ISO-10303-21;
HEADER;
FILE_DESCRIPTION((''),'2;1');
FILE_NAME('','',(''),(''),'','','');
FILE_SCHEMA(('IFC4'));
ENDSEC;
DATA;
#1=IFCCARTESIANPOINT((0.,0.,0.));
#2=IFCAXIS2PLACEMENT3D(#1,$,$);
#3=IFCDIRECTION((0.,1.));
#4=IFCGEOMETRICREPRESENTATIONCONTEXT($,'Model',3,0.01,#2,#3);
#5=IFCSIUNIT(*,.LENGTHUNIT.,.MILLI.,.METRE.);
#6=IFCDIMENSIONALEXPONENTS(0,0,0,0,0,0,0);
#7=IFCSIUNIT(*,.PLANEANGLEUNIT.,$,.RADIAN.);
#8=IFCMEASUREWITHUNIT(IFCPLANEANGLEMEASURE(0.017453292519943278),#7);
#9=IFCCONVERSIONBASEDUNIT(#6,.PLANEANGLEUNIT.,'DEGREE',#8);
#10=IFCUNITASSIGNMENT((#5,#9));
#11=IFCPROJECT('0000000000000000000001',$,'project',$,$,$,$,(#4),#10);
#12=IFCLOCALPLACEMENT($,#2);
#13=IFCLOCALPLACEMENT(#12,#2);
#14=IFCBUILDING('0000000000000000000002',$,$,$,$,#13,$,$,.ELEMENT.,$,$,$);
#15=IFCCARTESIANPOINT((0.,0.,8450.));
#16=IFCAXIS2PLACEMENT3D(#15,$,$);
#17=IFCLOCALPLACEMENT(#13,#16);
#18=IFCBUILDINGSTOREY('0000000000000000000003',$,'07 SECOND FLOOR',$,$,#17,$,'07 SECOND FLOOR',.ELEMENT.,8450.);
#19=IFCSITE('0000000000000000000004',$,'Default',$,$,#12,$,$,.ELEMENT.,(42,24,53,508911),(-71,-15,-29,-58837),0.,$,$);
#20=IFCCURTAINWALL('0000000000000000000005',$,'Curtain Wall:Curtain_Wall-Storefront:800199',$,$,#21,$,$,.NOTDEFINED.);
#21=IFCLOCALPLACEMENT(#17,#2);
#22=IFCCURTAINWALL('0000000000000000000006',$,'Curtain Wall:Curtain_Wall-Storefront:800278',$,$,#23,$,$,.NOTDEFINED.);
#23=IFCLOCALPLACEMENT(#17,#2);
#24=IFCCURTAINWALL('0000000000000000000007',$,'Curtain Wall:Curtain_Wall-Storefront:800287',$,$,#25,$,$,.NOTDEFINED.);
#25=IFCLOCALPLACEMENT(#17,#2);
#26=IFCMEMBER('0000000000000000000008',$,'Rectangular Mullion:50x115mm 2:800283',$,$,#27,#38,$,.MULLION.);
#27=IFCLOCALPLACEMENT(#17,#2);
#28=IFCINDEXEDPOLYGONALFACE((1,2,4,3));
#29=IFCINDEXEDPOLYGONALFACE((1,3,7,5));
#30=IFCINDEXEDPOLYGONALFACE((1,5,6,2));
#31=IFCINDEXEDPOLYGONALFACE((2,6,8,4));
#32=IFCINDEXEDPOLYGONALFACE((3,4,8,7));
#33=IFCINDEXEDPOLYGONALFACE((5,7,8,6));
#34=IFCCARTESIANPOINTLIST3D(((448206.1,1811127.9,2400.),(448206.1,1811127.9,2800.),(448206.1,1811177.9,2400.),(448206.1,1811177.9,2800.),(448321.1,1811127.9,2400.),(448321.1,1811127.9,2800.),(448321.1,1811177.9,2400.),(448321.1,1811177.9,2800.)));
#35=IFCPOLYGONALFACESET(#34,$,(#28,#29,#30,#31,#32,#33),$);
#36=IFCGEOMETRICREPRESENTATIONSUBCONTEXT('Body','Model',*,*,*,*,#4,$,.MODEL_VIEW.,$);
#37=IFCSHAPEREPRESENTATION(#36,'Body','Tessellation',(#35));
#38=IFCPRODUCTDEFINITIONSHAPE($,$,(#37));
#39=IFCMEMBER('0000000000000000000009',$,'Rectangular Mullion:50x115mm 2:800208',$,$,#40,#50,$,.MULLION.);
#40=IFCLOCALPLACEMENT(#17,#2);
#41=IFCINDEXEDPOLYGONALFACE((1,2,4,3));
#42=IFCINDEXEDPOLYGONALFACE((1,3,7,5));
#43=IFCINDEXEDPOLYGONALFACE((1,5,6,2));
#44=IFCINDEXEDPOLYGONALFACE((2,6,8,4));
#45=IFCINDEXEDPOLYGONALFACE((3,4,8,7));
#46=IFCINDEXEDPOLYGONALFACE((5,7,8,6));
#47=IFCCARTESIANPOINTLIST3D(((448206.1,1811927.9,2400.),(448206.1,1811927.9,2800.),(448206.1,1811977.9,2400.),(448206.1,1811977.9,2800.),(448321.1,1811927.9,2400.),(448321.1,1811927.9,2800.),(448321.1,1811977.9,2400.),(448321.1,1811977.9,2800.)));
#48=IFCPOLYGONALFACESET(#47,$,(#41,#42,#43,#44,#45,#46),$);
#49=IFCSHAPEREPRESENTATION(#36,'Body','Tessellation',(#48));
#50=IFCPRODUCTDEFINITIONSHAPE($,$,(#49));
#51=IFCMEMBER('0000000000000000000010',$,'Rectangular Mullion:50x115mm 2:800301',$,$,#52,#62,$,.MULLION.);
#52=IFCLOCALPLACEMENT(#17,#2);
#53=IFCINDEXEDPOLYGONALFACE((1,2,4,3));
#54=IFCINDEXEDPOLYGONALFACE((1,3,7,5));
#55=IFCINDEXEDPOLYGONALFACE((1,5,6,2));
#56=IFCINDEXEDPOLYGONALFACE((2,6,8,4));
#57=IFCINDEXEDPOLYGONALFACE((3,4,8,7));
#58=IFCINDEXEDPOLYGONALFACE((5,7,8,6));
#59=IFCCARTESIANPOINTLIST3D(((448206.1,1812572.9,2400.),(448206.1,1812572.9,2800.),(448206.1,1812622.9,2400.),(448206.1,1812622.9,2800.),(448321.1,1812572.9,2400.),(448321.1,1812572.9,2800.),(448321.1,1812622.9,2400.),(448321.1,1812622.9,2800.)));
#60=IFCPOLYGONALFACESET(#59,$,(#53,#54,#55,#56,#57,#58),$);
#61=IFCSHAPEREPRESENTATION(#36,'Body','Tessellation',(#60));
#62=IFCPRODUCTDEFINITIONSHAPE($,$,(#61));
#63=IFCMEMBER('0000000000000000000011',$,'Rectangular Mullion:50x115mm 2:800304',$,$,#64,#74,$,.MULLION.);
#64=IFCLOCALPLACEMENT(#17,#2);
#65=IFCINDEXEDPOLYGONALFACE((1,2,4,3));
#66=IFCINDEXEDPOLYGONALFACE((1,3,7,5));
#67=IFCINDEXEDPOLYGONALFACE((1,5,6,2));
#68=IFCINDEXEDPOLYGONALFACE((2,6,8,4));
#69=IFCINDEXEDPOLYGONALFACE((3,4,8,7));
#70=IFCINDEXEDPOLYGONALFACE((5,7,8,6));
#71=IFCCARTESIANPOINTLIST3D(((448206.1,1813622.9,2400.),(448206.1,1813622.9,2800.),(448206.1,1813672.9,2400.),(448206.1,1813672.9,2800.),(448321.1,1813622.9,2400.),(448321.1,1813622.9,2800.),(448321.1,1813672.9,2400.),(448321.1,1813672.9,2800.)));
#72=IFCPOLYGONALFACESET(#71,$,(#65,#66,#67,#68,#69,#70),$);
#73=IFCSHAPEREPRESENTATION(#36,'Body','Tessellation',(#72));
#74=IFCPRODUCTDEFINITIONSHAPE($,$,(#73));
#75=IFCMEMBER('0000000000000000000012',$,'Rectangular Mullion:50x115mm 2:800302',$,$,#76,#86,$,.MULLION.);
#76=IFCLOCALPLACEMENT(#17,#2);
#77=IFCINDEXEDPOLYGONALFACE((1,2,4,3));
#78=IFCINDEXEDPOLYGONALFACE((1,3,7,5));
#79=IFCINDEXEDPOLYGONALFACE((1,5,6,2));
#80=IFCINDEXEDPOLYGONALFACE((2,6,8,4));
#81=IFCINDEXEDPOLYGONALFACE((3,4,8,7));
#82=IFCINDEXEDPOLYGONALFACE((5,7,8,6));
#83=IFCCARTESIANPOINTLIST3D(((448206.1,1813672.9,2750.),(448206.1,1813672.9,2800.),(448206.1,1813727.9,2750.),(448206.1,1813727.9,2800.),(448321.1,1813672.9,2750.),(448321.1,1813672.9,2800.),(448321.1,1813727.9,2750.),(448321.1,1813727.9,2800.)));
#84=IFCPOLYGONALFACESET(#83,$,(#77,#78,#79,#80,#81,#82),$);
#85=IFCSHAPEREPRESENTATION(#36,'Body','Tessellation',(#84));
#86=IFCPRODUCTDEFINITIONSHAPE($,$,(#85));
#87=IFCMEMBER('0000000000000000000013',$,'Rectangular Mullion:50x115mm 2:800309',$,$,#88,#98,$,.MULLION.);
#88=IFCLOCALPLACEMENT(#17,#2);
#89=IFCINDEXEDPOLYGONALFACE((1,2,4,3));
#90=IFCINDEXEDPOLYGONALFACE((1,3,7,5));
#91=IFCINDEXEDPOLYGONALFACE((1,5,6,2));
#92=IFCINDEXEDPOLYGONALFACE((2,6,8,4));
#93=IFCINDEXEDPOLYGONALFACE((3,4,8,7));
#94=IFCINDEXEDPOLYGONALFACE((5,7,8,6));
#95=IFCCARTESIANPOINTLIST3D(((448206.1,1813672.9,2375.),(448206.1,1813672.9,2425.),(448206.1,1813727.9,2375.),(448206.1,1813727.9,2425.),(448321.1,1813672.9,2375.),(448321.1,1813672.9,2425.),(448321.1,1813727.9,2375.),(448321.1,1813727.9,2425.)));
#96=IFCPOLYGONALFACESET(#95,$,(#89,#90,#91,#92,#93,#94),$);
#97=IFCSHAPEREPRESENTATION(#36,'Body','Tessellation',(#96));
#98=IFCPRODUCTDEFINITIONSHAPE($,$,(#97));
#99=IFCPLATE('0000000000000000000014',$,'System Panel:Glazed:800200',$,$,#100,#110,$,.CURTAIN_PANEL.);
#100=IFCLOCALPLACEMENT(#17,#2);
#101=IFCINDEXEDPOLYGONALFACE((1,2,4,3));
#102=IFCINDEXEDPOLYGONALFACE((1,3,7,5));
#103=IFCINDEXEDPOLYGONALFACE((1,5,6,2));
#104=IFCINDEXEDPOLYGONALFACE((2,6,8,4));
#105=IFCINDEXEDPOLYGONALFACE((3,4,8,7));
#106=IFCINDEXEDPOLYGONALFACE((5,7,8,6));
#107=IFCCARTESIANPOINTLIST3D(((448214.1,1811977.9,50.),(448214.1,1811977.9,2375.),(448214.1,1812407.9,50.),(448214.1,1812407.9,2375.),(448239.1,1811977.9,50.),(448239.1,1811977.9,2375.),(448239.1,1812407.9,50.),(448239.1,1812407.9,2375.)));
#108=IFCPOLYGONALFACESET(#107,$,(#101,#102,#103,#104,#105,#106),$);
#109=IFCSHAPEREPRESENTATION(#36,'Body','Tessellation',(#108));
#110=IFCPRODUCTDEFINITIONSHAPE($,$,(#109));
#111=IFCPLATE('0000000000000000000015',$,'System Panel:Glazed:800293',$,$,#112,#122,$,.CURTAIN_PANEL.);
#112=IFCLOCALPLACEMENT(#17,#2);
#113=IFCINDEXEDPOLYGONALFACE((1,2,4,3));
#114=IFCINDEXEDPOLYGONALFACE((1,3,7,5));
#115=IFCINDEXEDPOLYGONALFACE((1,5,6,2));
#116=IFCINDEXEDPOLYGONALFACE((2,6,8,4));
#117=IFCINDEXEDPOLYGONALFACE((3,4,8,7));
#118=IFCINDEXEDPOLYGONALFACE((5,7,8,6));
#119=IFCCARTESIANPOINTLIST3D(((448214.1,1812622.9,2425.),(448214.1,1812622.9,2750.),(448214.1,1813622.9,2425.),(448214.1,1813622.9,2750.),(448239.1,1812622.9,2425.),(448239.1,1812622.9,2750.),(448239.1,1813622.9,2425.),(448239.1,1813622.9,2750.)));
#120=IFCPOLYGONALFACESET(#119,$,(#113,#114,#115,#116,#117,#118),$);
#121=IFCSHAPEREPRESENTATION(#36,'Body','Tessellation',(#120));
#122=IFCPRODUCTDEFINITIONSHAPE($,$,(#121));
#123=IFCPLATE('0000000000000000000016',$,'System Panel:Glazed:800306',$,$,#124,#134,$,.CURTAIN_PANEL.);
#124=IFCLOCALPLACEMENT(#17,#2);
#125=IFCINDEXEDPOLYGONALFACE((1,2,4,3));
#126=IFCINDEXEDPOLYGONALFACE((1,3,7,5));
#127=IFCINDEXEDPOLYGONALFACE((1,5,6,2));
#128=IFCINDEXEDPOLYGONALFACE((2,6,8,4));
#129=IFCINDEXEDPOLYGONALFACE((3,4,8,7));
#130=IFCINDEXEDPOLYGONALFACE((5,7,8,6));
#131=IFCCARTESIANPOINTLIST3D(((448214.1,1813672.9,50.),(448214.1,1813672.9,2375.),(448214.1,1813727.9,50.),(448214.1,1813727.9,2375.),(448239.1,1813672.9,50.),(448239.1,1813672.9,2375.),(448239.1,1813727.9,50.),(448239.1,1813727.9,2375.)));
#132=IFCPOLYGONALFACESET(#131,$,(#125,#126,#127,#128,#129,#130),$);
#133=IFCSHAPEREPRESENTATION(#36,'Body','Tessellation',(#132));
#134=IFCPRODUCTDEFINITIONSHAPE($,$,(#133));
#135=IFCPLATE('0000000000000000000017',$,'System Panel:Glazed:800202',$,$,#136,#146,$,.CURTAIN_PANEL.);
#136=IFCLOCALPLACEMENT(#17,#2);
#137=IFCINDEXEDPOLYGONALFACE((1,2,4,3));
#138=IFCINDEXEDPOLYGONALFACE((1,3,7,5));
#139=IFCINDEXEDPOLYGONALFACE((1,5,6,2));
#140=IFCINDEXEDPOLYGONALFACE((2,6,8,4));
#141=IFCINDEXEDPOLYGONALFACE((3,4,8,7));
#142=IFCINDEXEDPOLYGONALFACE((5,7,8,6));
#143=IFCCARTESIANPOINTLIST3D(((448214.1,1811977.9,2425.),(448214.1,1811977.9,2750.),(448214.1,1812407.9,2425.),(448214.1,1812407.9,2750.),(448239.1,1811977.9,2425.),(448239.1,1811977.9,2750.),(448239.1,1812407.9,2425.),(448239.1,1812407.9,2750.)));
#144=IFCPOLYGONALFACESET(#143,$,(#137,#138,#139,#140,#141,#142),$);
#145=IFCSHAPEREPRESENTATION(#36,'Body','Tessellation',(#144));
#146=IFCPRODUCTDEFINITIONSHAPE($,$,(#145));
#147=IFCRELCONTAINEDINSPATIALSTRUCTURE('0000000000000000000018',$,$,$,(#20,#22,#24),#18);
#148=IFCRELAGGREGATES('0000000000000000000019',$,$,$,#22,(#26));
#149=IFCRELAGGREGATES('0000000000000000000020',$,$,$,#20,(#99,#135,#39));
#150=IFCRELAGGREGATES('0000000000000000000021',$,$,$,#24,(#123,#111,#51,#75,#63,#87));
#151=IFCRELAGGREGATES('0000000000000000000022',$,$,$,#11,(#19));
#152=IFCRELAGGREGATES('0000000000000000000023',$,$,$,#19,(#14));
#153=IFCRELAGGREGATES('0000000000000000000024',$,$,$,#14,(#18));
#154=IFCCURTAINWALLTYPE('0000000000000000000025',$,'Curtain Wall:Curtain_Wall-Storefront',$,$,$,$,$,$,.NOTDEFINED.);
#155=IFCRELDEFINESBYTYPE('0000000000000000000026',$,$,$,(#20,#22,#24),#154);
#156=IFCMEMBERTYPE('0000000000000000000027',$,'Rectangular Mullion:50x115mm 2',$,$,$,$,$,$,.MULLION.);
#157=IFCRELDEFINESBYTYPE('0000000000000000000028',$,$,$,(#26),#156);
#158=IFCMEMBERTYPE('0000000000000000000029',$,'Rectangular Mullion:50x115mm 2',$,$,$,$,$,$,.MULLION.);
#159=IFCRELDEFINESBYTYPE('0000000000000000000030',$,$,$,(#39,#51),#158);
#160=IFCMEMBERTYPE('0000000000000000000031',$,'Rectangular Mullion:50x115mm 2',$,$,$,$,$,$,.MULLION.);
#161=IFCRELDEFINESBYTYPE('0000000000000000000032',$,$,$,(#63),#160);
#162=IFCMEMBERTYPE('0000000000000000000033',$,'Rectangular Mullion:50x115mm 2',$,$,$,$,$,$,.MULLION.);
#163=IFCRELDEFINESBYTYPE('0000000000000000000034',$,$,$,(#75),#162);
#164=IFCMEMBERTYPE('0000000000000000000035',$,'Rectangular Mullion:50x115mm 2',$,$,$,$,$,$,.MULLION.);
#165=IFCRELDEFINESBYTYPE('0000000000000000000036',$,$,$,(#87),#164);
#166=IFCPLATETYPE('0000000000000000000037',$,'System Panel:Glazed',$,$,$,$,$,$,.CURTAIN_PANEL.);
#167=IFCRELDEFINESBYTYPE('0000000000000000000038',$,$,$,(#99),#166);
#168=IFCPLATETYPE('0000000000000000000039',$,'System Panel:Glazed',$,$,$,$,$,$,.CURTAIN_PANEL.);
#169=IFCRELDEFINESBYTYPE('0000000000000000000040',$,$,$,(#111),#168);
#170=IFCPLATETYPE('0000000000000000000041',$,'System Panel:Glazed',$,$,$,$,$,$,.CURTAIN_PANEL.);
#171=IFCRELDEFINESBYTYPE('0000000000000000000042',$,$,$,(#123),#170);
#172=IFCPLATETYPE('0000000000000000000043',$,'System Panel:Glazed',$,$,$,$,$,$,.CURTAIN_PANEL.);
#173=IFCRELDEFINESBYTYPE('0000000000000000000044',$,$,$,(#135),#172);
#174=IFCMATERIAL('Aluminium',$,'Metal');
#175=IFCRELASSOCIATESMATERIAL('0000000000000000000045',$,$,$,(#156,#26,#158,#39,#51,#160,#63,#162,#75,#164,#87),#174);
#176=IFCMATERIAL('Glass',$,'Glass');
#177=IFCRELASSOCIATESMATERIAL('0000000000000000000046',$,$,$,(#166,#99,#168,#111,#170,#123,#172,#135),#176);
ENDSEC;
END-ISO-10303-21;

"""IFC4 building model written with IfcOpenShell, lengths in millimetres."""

from ifc_helpers import new_model, entity, si_unit, converted_unit, direction, frame, origin, place, context, subcontext, project, spatial, indexed_curve, outline, extrude, source, transform, mapped, material, type_object, type_shapes, element, aggregate, save


model = new_model("IFC4")

# Units and contexts
model_context = context("Model", 3, precision=0.01, world=origin(), true_north=direction((0.0, 1.0)))
body_context = subcontext(model_context, "Body", "Model", "MODEL_VIEW")
ifc_project = project(units=[si_unit("LENGTHUNIT", "METRE", prefix="MILLI"), converted_unit("PLANEANGLEUNIT", "DEGREE", entity("IfcPlaneAngleMeasure", 0.017453292519943278), si_unit("PLANEANGLEUNIT", "RADIAN"), dimensions=[0, 0, 0, 0, 0, 0, 0])], contexts=[model_context])

# Site, building, storey
site_placement = place(None, origin())
site = spatial("IfcSite", under=ifc_project, at=site_placement, Name="Default", CompositionType="ELEMENT", RefLatitude=(42, 24, 53, 508911), RefLongitude=(-71, -15, -29, -58837), RefElevation=0.0)
building_placement = place(site_placement, origin())
building = spatial("IfcBuilding", under=site, at=building_placement, CompositionType="ELEMENT")
storey_placement = place(building_placement, frame((0.0, 0.0, 8450.0)))
storey = spatial("IfcBuildingStorey", under=building, at=storey_placement, Name="07 SECOND FLOOR", LongName="07 SECOND FLOOR", CompositionType="ELEMENT", Elevation=8450.0)

# Curtain wall
curtain_wall_type = type_object("IfcCurtainWallType", Name="Curtain Wall:Curtain_Wall-Storefront", PredefinedType="NOTDEFINED")
curtain_wall_1_placement = place(storey_placement, frame((0.0, 0.0, -8450.0)))
curtain_wall_1 = element("IfcCurtainWall", 1, at=curtain_wall_1_placement, inside=storey, type_object=curtain_wall_type, Name="Curtain Wall:Curtain_Wall-Storefront:800199", PredefinedType="NOTDEFINED")
ifc_material_1 = material(Name="Aluminium", Category="Metal")

# Curtain wall
curtain_wall_2_placement = place(storey_placement, frame((0.0, 0.0, -8450.0)))
curtain_wall_2 = element("IfcCurtainWall", 2, at=curtain_wall_2_placement, inside=storey, type_object=curtain_wall_type, Name="Curtain Wall:Curtain_Wall-Storefront:800278", PredefinedType="NOTDEFINED")

# Curtain wall
curtain_wall_3_placement = place(storey_placement, frame((0.0, 0.0, -8450.0)))
curtain_wall_3 = element("IfcCurtainWall", 3, at=curtain_wall_3_placement, inside=storey, type_object=curtain_wall_type, Name="Curtain Wall:Curtain_Wall-Storefront:800287", PredefinedType="NOTDEFINED")

# Members
member_type_1 = type_object("IfcMemberType", Name="Rectangular Mullion:50x115mm 2", PredefinedType="MULLION", material=ifc_material_1)
shared_shape_1 = source(origin(), body_context, "Body", "SweptSolid", [
    extrude(outline(indexed_curve([(-25.0, -57.5), (25.0, -57.5), (25.0, 57.5), (-25.0, 57.5), (-25.0, -57.5)], self_intersect=False)), frame((-25.0, 0.0, -400.0), z_axis=(0.0, 0.0, 1.0), x_axis=(-1.0, 0.0, 0.0)), (0.0, 0.0, 1.0), 400.0),
])
type_shapes(member_type_1, [shared_shape_1])
member_1_placement = place(curtain_wall_2_placement, frame((448263.6, 1811177.9, 11250.0), z_axis=(0.0, 0.0, 1.0), x_axis=(0.0, 1.0, 0.0)))
member_1 = element("IfcMember", 4, at=member_1_placement, type_object=member_type_1, material=ifc_material_1, Name="Rectangular Mullion:50x115mm 2:800283", PredefinedType="MULLION", context=body_context, shape_type="MappedRepresentation", body=[
    mapped(shared_shape_1, transform((0.0, 0.0, 0.0), scale=1.0)),
])
aggregate(curtain_wall_2, [member_1])
member_type_2 = type_object("IfcMemberType", Name="Rectangular Mullion:50x115mm 2", PredefinedType="MULLION", material=ifc_material_1)
shared_shape_2 = source(origin(), body_context, "Body", "SweptSolid", [
    extrude(outline(indexed_curve([(-25.0, -57.5), (25.0, -57.5), (25.0, 57.5), (-25.0, 57.5), (-25.0, -57.5)], self_intersect=False)), frame((-25.0, 0.0, -400.0), z_axis=(0.0, 0.0, 1.0), x_axis=(-1.0, 0.0, 0.0)), (0.0, 0.0, 1.0), 400.0),
])
type_shapes(member_type_2, [shared_shape_2])
member_2_placement = place(curtain_wall_1_placement, frame((448263.6, 1811927.9, 10850.0), z_axis=(0.0, 0.0, -1.0), x_axis=(0.0, -1.0, 0.0)))
member_2 = element("IfcMember", 5, at=member_2_placement, type_object=member_type_2, material=ifc_material_1, Name="Rectangular Mullion:50x115mm 2:800208", PredefinedType="MULLION", context=body_context, shape_type="MappedRepresentation", body=[
    mapped(shared_shape_2, transform((0.0, 0.0, 0.0), scale=1.0)),
])
member_3_placement = place(curtain_wall_3_placement, frame((448263.6, 1812572.9, 10850.0), z_axis=(0.0, 0.0, -1.0), x_axis=(0.0, -1.0, 0.0)))
member_3 = element("IfcMember", 6, at=member_3_placement, type_object=member_type_2, material=ifc_material_1, Name="Rectangular Mullion:50x115mm 2:800301", PredefinedType="MULLION", context=body_context, shape_type="MappedRepresentation", body=[
    mapped(shared_shape_2, transform((0.0, 0.0, 0.0), scale=1.0)),
])
member_type_3 = type_object("IfcMemberType", Name="Rectangular Mullion:50x115mm 2", PredefinedType="MULLION", material=ifc_material_1)
shared_shape_3 = source(origin(), body_context, "Body", "SweptSolid", [
    extrude(outline(indexed_curve([(-25.0, -57.5), (25.0, -57.5), (25.0, 57.5), (-25.0, 57.5), (-25.0, -57.5)], self_intersect=False)), frame((0.0, 0.0, -400.0), z_axis=(0.0, 0.0, 1.0), x_axis=(-1.0, 0.0, 0.0)), (0.0, 0.0, 1.0), 400.0),
])
type_shapes(member_type_3, [shared_shape_3])
member_4_placement = place(curtain_wall_3_placement, frame((448263.6, 1813647.9, 10850.0), z_axis=(0.0, 0.0, -1.0), x_axis=(0.0, -1.0, 0.0)))
member_4 = element("IfcMember", 7, at=member_4_placement, type_object=member_type_3, material=ifc_material_1, Name="Rectangular Mullion:50x115mm 2:800304", PredefinedType="MULLION", context=body_context, shape_type="MappedRepresentation", body=[
    mapped(shared_shape_3, transform((0.0, 0.0, 0.0), scale=1.0)),
])
member_type_4 = type_object("IfcMemberType", Name="Rectangular Mullion:50x115mm 2", PredefinedType="MULLION", material=ifc_material_1)
shared_shape_4 = source(origin(), body_context, "Body", "SweptSolid", [
    extrude(outline(indexed_curve([(-25.0, -57.5), (25.0, -57.5), (25.0, 57.5), (-25.0, 57.5), (-25.0, -57.5)], self_intersect=False)), frame((-25.0, 0.0, -55.0), z_axis=(0.0, 0.0, 1.0), x_axis=(-1.0, 0.0, 0.0)), (0.0, 0.0, 1.0), 55.0),
])
type_shapes(member_type_4, [shared_shape_4])
member_5_placement = place(curtain_wall_3_placement, frame((448263.6, 1813672.9, 11250.0), z_axis=(0.0, -1.0, 0.0), x_axis=(0.0, 0.0, 1.0)))
member_5 = element("IfcMember", 8, at=member_5_placement, type_object=member_type_4, material=ifc_material_1, Name="Rectangular Mullion:50x115mm 2:800302", PredefinedType="MULLION", context=body_context, shape_type="MappedRepresentation", body=[
    mapped(shared_shape_4, transform((0.0, 0.0, 0.0), scale=1.0)),
])
member_type_5 = type_object("IfcMemberType", Name="Rectangular Mullion:50x115mm 2", PredefinedType="MULLION", material=ifc_material_1)
shared_shape_5 = source(origin(), body_context, "Body", "SweptSolid", [
    extrude(outline(indexed_curve([(-25.0, -57.5), (25.0, -57.5), (25.0, 57.5), (-25.0, 57.5), (-25.0, -57.5)], self_intersect=False)), frame((0.0, 0.0, -55.0), z_axis=(0.0, 0.0, 1.0), x_axis=(-1.0, 0.0, 0.0)), (0.0, 0.0, 1.0), 55.0),
])
type_shapes(member_type_5, [shared_shape_5])
member_6_placement = place(curtain_wall_3_placement, frame((448263.6, 1813672.9, 10850.0), z_axis=(0.0, -1.0, 0.0), x_axis=(0.0, 0.0, 1.0)))
member_6 = element("IfcMember", 9, at=member_6_placement, type_object=member_type_5, material=ifc_material_1, Name="Rectangular Mullion:50x115mm 2:800309", PredefinedType="MULLION", context=body_context, shape_type="MappedRepresentation", body=[
    mapped(shared_shape_5, transform((0.0, 0.0, 0.0), scale=1.0)),
])

# Plates
ifc_material_2 = material(Name="Glass", Category="Glass")
plate_type_1 = type_object("IfcPlateType", Name="System Panel:Glazed", PredefinedType="CURTAIN_PANEL", material=ifc_material_2)
shared_shape_6 = source(origin(), body_context, "Body", "SweptSolid", [
    extrude(outline(indexed_curve([(-12.5, -215.0), (12.5, -215.0), (12.5, 215.0), (-12.5, 215.0), (-12.5, -215.0)], self_intersect=False)), frame((0.0, -37.0, 0.0), z_axis=(0.0, 0.0, 1.0), x_axis=(0.0, 1.0, 0.0)), (0.0, 0.0, 1.0), 2325.0),
])
type_shapes(plate_type_1, [shared_shape_6])
plate_1_placement = place(curtain_wall_1_placement, frame((448263.6, 1812192.9, 8500.0), z_axis=(0.0, 0.0, 1.0), x_axis=(0.0, -1.0, 0.0)))
plate_1 = element("IfcPlate", 10, at=plate_1_placement, type_object=plate_type_1, material=ifc_material_2, Name="System Panel:Glazed:800200", PredefinedType="CURTAIN_PANEL", context=body_context, shape_type="MappedRepresentation", body=[
    mapped(shared_shape_6, transform((0.0, 0.0, 0.0), scale=1.0)),
])
plate_type_2 = type_object("IfcPlateType", Name="System Panel:Glazed", PredefinedType="CURTAIN_PANEL", material=ifc_material_2)
shared_shape_7 = source(origin(), body_context, "Body", "SweptSolid", [
    extrude(outline(indexed_curve([(-12.5, -500.0), (12.5, -500.0), (12.5, 500.0), (-12.5, 500.0), (-12.5, -500.0)], self_intersect=False)), frame((0.0, -37.0, 0.0), z_axis=(0.0, 0.0, 1.0), x_axis=(0.0, 1.0, 0.0)), (0.0, 0.0, 1.0), 325.0),
])
type_shapes(plate_type_2, [shared_shape_7])
plate_2_placement = place(curtain_wall_3_placement, frame((448263.6, 1813122.9, 10875.0), z_axis=(0.0, 0.0, 1.0), x_axis=(0.0, -1.0, 0.0)))
plate_2 = element("IfcPlate", 11, at=plate_2_placement, type_object=plate_type_2, material=ifc_material_2, Name="System Panel:Glazed:800293", PredefinedType="CURTAIN_PANEL", context=body_context, shape_type="MappedRepresentation", body=[
    mapped(shared_shape_7, transform((0.0, 0.0, 0.0), scale=1.0)),
])
plate_type_3 = type_object("IfcPlateType", Name="System Panel:Glazed", PredefinedType="CURTAIN_PANEL", material=ifc_material_2)
shared_shape_8 = source(origin(), body_context, "Body", "SweptSolid", [
    extrude(outline(indexed_curve([(-12.5, -27.5), (12.5, -27.5), (12.5, 27.5), (-12.5, 27.5), (-12.5, -27.5)], self_intersect=False)), frame((0.0, -37.0, 0.0), z_axis=(0.0, 0.0, 1.0), x_axis=(0.0, 1.0, 0.0)), (0.0, 0.0, 1.0), 2325.0),
])
type_shapes(plate_type_3, [shared_shape_8])
plate_3_placement = place(curtain_wall_3_placement, frame((448263.6, 1813700.4, 8500.0), z_axis=(0.0, 0.0, 1.0), x_axis=(0.0, -1.0, 0.0)))
plate_3 = element("IfcPlate", 12, at=plate_3_placement, type_object=plate_type_3, material=ifc_material_2, Name="System Panel:Glazed:800306", PredefinedType="CURTAIN_PANEL", context=body_context, shape_type="MappedRepresentation", body=[
    mapped(shared_shape_8, transform((0.0, 0.0, 0.0), scale=1.0)),
])
plate_type_4 = type_object("IfcPlateType", Name="System Panel:Glazed", PredefinedType="CURTAIN_PANEL", material=ifc_material_2)
shared_shape_9 = source(origin(), body_context, "Body", "SweptSolid", [
    extrude(outline(indexed_curve([(-12.5, -215.0), (12.5, -215.0), (12.5, 215.0), (-12.5, 215.0), (-12.5, -215.0)], self_intersect=False)), frame((0.0, -37.0, 0.0), z_axis=(0.0, 0.0, 1.0), x_axis=(0.0, 1.0, 0.0)), (0.0, 0.0, 1.0), 325.0),
])
type_shapes(plate_type_4, [shared_shape_9])
plate_4_placement = place(curtain_wall_1_placement, frame((448263.6, 1812192.9, 10875.0), z_axis=(0.0, 0.0, 1.0), x_axis=(0.0, -1.0, 0.0)))
plate_4 = element("IfcPlate", 13, at=plate_4_placement, type_object=plate_type_4, material=ifc_material_2, Name="System Panel:Glazed:800202", PredefinedType="CURTAIN_PANEL", context=body_context, shape_type="MappedRepresentation", body=[
    mapped(shared_shape_9, transform((0.0, 0.0, 0.0), scale=1.0)),
])
aggregate(curtain_wall_1, [plate_1, plate_4, member_2])

aggregate(curtain_wall_3, [plate_3, plate_2, member_3, member_5, member_4, member_6])

save(model, "model.ifc")
